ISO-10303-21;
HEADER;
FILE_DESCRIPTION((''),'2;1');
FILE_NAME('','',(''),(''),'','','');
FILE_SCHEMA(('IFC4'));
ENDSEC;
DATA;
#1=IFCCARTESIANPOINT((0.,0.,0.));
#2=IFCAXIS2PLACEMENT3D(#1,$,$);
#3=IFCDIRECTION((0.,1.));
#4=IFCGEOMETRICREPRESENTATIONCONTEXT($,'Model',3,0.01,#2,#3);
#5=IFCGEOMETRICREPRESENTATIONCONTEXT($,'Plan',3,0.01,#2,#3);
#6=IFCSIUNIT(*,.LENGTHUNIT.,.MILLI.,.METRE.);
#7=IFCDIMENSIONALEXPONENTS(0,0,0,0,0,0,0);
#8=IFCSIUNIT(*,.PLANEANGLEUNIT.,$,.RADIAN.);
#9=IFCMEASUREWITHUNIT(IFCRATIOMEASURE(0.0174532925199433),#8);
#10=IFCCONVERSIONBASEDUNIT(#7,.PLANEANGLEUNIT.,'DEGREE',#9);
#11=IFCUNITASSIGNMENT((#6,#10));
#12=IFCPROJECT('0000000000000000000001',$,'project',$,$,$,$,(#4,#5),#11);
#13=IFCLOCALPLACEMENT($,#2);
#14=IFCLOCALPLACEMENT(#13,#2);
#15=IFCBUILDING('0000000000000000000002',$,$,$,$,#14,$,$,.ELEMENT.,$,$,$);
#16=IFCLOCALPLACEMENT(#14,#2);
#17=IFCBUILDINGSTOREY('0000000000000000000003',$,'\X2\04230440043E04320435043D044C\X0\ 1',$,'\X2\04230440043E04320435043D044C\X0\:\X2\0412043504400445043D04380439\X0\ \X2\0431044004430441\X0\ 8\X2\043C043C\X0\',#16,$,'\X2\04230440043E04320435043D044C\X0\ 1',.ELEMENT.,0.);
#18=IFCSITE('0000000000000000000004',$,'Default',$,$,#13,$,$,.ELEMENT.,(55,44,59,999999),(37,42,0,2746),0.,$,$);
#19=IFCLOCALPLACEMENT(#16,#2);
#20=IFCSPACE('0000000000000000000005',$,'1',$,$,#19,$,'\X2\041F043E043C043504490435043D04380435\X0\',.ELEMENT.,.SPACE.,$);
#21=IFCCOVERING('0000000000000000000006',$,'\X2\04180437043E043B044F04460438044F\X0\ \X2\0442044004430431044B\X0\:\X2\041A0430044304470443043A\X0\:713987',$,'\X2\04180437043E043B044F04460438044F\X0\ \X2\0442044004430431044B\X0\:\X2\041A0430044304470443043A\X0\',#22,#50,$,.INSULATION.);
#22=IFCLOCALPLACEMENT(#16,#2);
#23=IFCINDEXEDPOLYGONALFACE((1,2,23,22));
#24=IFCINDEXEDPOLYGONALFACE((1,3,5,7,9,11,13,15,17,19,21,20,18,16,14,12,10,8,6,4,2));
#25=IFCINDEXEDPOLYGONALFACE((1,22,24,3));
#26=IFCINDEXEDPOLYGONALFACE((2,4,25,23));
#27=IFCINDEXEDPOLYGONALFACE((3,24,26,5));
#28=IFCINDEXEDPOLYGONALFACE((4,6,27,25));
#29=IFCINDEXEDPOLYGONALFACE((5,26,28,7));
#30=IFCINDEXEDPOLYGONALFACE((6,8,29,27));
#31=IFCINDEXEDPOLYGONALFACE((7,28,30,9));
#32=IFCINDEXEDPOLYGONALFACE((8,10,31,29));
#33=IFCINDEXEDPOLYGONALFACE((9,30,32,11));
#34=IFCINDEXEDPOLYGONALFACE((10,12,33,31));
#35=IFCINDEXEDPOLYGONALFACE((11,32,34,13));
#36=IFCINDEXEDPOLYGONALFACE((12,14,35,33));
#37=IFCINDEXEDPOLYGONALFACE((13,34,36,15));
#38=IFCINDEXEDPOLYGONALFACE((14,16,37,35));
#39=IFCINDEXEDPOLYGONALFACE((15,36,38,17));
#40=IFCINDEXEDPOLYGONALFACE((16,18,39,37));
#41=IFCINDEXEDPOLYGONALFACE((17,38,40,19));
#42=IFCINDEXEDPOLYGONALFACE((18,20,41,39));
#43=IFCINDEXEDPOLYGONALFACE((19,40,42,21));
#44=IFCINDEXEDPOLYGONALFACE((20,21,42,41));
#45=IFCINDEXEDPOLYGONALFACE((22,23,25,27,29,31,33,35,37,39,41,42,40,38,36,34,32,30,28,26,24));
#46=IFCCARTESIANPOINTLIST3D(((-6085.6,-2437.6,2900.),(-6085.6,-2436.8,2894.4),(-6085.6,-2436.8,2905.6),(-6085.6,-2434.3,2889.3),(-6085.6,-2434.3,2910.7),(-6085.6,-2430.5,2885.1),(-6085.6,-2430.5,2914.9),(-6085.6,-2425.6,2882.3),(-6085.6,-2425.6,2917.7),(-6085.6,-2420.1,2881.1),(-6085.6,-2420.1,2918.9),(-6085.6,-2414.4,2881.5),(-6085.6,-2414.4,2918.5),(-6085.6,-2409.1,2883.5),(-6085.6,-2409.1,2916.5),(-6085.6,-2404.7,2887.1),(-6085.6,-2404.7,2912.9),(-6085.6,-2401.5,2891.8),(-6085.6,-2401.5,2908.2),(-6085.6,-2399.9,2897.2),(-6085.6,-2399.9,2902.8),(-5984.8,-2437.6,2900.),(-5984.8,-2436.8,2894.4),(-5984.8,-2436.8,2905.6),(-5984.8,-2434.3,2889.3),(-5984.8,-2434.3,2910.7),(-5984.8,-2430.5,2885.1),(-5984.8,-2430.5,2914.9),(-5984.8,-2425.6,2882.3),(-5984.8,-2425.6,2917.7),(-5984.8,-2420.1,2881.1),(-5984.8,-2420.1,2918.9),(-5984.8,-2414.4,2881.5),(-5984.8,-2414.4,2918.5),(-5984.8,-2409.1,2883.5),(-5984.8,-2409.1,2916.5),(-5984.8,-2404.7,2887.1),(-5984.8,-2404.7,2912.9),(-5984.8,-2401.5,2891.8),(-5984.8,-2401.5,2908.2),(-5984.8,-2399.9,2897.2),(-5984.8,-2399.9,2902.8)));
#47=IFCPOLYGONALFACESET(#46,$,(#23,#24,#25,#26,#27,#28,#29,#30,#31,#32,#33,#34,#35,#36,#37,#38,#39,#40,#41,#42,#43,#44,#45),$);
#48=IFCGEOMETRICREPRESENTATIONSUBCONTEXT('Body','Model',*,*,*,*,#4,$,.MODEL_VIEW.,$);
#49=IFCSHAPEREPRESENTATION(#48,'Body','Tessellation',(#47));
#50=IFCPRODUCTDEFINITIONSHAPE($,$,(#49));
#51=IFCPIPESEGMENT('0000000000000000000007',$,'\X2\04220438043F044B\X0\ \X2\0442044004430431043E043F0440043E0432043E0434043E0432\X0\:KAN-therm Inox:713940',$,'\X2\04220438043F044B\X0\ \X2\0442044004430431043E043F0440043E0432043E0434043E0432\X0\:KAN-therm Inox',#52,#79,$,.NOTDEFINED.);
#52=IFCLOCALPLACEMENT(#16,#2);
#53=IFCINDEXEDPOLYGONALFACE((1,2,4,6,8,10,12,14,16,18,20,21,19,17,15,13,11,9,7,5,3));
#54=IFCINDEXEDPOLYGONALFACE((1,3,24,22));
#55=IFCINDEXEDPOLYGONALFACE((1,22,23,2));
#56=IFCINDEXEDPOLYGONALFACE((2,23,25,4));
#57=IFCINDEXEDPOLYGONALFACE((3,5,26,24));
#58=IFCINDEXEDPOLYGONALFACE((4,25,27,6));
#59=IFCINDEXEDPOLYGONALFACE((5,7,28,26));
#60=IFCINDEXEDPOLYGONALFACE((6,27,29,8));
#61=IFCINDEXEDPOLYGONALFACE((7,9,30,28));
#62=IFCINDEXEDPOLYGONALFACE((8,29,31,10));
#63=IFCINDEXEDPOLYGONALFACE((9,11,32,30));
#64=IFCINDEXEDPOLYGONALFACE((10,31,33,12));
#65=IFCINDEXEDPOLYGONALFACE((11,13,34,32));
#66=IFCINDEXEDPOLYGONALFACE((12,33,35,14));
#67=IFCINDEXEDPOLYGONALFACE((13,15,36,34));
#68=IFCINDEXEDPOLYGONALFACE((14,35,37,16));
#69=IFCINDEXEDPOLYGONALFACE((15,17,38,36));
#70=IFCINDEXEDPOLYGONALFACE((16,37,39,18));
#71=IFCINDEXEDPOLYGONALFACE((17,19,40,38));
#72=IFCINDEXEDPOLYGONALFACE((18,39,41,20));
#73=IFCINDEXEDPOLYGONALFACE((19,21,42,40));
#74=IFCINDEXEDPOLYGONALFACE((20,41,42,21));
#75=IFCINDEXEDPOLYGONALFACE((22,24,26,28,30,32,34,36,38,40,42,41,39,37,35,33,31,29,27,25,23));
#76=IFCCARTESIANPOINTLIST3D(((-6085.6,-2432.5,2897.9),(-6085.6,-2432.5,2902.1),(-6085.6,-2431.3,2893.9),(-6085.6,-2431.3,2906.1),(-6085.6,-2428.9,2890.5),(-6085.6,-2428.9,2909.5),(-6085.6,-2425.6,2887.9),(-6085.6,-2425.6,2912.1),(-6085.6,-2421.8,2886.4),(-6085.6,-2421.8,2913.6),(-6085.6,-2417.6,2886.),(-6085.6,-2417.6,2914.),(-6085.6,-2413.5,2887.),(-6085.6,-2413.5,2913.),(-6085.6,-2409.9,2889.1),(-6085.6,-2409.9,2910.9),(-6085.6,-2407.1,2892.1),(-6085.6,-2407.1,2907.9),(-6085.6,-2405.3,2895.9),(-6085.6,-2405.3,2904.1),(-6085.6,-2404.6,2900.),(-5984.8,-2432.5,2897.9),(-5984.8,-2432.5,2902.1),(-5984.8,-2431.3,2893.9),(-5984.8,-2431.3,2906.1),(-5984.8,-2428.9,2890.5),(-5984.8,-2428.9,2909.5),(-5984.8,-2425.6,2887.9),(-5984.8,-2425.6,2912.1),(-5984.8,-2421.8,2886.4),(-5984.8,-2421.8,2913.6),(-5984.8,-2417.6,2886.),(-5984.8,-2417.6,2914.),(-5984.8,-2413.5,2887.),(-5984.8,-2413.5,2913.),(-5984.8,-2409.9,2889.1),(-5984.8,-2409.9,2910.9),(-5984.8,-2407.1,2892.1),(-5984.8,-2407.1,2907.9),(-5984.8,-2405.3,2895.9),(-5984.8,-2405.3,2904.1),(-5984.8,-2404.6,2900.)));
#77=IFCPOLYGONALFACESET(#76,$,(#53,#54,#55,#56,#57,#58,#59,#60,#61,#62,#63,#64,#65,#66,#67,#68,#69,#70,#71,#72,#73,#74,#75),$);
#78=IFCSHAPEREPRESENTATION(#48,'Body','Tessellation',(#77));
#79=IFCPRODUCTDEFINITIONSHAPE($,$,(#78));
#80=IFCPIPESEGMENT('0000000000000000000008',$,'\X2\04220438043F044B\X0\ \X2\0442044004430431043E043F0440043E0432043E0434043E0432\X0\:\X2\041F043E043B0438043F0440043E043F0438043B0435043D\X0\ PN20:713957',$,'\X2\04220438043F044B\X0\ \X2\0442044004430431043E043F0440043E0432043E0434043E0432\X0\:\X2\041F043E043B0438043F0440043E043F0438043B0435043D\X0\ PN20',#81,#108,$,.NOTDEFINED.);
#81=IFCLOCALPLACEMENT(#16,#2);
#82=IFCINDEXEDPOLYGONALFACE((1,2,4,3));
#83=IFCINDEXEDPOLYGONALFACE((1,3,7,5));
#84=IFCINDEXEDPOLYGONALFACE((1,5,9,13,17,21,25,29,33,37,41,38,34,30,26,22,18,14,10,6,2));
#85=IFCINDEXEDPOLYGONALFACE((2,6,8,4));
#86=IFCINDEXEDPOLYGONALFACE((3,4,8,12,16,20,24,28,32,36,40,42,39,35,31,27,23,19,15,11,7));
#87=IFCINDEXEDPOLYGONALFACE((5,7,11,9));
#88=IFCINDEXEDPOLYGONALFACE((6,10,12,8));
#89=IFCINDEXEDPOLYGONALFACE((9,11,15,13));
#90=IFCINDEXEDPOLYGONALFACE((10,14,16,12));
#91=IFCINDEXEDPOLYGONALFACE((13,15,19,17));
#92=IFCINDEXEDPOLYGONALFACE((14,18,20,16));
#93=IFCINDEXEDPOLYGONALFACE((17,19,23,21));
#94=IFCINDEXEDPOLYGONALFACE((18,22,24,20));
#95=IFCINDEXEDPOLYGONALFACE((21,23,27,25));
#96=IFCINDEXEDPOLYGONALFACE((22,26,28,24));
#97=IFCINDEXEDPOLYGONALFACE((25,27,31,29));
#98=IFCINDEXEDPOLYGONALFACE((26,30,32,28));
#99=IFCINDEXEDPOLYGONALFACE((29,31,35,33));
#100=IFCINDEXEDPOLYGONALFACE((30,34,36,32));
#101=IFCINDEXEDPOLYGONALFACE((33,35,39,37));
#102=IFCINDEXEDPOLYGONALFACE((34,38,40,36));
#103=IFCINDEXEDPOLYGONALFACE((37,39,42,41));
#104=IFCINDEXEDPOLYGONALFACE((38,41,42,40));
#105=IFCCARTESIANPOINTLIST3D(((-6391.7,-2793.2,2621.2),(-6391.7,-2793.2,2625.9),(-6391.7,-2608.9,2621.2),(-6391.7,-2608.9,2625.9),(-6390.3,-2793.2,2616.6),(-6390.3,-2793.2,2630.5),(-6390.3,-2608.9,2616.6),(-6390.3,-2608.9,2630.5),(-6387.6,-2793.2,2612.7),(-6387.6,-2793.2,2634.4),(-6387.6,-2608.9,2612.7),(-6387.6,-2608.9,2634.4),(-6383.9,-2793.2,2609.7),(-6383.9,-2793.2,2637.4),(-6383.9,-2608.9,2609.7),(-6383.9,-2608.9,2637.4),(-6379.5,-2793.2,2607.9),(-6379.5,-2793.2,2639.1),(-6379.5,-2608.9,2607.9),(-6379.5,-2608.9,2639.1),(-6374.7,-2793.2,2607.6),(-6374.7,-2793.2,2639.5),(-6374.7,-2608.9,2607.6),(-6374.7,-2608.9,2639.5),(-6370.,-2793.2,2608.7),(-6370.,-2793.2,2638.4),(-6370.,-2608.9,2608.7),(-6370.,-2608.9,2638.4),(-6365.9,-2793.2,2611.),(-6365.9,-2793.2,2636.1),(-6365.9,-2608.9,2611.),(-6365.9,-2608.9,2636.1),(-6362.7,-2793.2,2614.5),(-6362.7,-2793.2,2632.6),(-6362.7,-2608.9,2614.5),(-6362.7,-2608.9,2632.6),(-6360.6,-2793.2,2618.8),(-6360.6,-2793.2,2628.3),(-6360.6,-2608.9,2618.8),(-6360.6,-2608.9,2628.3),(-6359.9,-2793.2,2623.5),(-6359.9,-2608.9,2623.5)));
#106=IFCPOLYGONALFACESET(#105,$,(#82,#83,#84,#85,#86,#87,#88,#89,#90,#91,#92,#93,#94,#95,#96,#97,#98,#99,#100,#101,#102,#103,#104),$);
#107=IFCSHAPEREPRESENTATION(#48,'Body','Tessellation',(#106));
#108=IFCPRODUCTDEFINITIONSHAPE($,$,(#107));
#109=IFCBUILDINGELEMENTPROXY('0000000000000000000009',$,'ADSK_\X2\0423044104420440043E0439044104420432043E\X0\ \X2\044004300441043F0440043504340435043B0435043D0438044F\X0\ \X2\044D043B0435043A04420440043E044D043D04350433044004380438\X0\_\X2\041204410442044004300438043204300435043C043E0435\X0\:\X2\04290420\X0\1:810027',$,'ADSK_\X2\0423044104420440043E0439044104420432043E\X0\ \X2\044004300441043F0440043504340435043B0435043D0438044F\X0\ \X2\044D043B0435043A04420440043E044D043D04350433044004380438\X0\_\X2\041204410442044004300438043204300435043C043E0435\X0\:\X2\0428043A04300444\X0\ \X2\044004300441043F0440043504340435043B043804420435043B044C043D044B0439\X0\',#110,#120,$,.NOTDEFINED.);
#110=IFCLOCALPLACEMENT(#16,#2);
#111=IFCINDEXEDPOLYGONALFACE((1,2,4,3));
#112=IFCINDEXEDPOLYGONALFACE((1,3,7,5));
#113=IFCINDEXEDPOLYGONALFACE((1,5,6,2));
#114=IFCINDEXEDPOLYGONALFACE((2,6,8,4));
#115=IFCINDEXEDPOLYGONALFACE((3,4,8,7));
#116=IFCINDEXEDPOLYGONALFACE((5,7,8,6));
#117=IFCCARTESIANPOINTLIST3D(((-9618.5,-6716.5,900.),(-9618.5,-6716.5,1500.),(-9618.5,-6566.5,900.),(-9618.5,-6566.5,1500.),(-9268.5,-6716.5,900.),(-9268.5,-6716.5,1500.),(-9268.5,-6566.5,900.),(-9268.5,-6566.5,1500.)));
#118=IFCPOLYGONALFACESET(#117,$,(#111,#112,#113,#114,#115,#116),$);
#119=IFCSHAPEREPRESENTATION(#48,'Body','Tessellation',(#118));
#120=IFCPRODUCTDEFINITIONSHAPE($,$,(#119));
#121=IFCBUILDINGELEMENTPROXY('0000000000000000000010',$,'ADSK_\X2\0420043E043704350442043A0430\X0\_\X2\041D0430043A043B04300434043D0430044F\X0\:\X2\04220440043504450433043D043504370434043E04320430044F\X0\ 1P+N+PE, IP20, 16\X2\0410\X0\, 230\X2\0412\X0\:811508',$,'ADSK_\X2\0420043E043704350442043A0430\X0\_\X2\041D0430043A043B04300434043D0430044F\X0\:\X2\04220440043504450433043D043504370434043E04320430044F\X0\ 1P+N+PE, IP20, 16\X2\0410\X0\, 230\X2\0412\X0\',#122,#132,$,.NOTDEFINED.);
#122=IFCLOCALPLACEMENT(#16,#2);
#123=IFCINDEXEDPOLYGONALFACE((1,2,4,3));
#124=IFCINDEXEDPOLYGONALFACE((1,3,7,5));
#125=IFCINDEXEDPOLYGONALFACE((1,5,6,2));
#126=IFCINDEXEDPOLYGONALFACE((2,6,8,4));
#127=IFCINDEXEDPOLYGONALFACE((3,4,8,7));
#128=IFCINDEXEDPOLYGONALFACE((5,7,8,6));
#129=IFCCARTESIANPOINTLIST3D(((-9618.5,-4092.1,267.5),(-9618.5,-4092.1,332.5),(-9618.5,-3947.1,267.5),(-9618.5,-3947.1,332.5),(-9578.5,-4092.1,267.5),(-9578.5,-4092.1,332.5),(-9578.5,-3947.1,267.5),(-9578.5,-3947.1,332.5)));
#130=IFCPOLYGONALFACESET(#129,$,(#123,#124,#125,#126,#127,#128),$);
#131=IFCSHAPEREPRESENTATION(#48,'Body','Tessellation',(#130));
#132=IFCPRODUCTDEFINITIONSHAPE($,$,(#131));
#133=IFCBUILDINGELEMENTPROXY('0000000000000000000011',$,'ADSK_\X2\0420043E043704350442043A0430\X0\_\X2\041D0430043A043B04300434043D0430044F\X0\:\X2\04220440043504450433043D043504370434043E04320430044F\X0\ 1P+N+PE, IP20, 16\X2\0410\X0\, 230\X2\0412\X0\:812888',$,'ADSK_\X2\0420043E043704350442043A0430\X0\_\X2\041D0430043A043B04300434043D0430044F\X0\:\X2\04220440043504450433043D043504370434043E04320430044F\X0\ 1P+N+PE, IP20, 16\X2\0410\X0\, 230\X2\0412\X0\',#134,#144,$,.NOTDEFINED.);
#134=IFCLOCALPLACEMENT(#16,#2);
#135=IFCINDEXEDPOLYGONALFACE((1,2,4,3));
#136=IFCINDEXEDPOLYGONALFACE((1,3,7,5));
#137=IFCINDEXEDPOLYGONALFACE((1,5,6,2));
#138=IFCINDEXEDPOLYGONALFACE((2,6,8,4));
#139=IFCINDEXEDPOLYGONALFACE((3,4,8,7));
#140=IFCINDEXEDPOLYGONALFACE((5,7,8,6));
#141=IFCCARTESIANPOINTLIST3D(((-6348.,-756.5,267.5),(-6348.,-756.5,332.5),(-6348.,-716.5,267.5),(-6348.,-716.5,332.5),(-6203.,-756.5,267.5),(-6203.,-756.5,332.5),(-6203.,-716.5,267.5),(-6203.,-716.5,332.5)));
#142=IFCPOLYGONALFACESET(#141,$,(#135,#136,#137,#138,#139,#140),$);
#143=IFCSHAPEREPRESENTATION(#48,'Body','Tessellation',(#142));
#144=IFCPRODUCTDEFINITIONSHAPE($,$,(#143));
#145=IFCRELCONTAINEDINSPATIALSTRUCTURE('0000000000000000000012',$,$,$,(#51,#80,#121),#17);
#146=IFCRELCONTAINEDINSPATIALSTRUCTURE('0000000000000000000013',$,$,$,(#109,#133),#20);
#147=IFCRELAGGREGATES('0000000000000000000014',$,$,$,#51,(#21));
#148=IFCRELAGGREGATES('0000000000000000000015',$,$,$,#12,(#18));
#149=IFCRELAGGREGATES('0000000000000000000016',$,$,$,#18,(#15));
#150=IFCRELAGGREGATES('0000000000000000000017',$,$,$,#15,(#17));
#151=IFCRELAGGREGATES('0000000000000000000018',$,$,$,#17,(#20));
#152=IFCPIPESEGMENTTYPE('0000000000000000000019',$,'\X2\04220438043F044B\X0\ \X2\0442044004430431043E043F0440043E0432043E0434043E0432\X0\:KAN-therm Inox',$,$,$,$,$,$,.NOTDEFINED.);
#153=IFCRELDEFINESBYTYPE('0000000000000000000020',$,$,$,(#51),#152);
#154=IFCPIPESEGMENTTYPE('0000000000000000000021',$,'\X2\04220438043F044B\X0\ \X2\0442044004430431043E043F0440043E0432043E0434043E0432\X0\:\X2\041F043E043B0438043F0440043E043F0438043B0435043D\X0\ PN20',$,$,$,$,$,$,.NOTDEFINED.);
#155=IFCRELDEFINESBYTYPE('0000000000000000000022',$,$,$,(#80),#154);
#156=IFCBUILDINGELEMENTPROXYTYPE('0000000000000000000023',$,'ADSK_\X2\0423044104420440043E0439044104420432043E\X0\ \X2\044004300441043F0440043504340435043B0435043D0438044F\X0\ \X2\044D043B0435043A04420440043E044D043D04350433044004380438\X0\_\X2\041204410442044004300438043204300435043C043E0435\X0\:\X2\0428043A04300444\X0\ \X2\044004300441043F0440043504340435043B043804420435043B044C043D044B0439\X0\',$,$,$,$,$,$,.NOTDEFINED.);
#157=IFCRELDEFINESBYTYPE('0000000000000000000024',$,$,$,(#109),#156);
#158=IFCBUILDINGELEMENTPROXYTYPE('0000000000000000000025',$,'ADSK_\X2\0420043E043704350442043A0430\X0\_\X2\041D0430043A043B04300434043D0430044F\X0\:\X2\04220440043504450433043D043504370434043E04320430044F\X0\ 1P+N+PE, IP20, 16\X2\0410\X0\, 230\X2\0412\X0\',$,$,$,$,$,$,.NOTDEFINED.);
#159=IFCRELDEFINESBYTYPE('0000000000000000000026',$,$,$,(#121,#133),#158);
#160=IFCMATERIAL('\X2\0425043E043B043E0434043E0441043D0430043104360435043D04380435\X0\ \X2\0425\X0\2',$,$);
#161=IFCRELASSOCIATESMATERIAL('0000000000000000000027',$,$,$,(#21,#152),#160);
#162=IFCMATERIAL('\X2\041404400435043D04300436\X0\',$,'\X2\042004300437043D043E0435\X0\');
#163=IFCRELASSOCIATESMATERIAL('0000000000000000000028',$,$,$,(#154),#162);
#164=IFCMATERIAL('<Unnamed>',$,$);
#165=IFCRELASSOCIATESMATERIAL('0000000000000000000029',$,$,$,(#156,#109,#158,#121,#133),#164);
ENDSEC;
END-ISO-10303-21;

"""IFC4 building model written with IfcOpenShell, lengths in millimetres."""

from ifc_helpers import new_model, entity, si_unit, converted_unit, direction, frame, frame_2d, origin, origin_2d_with_axis, place, context, subcontext, project, spatial, rectangle, circle, extrude, source, transform, mapped, material, type_object, type_shapes, element, aggregate, save


model = new_model("IFC4")

# Units and contexts
model_context = context("Model", 3, precision=0.01, world=origin(), true_north=direction((0.0, 1.0)))
plan_context = context("Plan", 3, precision=0.01, world=origin(), true_north=direction((0.0, 1.0)))
body_context = subcontext(model_context, "Body", "Model", "MODEL_VIEW")
ifc_project = project(units=[si_unit("LENGTHUNIT", "METRE", prefix="MILLI"), converted_unit("PLANEANGLEUNIT", "DEGREE", entity("IfcRatioMeasure", 0.0174532925199433), si_unit("PLANEANGLEUNIT", "RADIAN"), dimensions=[0, 0, 0, 0, 0, 0, 0])], contexts=[model_context, plan_context])

# Site, building, storey
site_placement = place(None, origin())
site = spatial("IfcSite", under=ifc_project, at=site_placement, Name="Default", CompositionType="ELEMENT", RefLatitude=(55, 44, 59, 999999), RefLongitude=(37, 42, 0, 2746), RefElevation=0.0)
building_placement = place(site_placement, origin())
building = spatial("IfcBuilding", under=site, at=building_placement, CompositionType="ELEMENT")
storey_placement = place(building_placement, origin())
storey = spatial("IfcBuildingStorey", under=building, at=storey_placement, Name="Уровень 1", ObjectType="Уровень:Верхний брус 8мм", LongName="Уровень 1", CompositionType="ELEMENT", Elevation=0.0)

# Covering
ifc_material_1 = material(Name="Холодоснабжение Х2")
covering_1_placement = place(storey_placement, frame((-6085.6, -2439.2, 2879.4)))
covering_1 = element("IfcCovering", 1, at=covering_1_placement, material=ifc_material_1, Name="Изоляция трубы:Каучук:713987", ObjectType="Изоляция трубы:Каучук", PredefinedType="INSULATION", context=body_context, shape_type="SweptSolid", body=[
    extrude(circle(Radius=19.0, at=frame_2d((0.0, 0.0), x_axis=(1.0, 0.0))), frame((0.0, 20.6, 20.6), z_axis=(1.0, 0.0, 0.0), x_axis=(0.0, -1.0, 0.0)), (0.0, 0.0, 1.0), 100.8),
])

# Pipe segment
pipe_segment_type_1 = type_object("IfcPipeSegmentType", Name="Типы трубопроводов:KAN-therm Inox", PredefinedType="NOTDEFINED", material=ifc_material_1)
pipe_segment_1_placement = place(storey_placement, frame((-6085.6, -2434.2, 2884.4)))
pipe_segment_1 = element("IfcPipeSegment", 2, at=pipe_segment_1_placement, inside=storey, type_object=pipe_segment_type_1, Name="Типы трубопроводов:KAN-therm Inox:713940", ObjectType="Типы трубопроводов:KAN-therm Inox", PredefinedType="NOTDEFINED", context=body_context, shape_type="SweptSolid", body=[
    extrude(circle(Radius=14.0, at=origin_2d_with_axis()), frame((0.0, 15.6, 15.6), z_axis=(1.0, 0.0, 0.0), x_axis=(0.0, 1.0, 0.0)), (0.0, 0.0, 1.0), 100.8),
])
aggregate(pipe_segment_1, [covering_1])

# Pipe segment
ifc_material_2 = material(Name="Дренаж", Category="Разное")
pipe_segment_type_2 = type_object("IfcPipeSegmentType", Name="Типы трубопроводов:Полипропилен PN20", PredefinedType="NOTDEFINED", material=ifc_material_2)
pipe_segment_2_placement = place(storey_placement, frame((-6393.5, -2793.2, 2606.0)))
element("IfcPipeSegment", 3, at=pipe_segment_2_placement, inside=storey, type_object=pipe_segment_type_2, Name="Типы трубопроводов:Полипропилен PN20:713957", ObjectType="Типы трубопроводов:Полипропилен PN20", PredefinedType="NOTDEFINED", context=body_context, shape_type="SweptSolid", body=[
    extrude(circle(Radius=16.0, at=frame_2d((0.0, 0.0), x_axis=(1.0, 0.0))), frame((17.6, 0.0, 17.6), z_axis=(-0.000002, 1.0, 0.0), x_axis=(1.0, 0.000002, 0.0)), (0.0, 0.0, 1.0), 184.3),
])

# Shared definitions
space_placement = place(storey_placement, origin())
space = spatial("IfcSpace", under=storey, at=space_placement, Name="1", LongName="Помещение", CompositionType="ELEMENT", PredefinedType="SPACE")

# Building element proxies
ifc_material_3 = material(Name="<Unnamed>")
building_element_proxy_type_1 = type_object("IfcBuildingElementProxyType", Name="ADSK_Устройство распределения электроэнегрии_Встраиваемое:Шкаф распределительный", PredefinedType="NOTDEFINED", material=ifc_material_3)
shared_shape_1 = source(origin(), body_context, "Body", "SweptSolid", [
    extrude(rectangle(XDim=150.0, YDim=350.0, at=origin_2d_with_axis()), frame((0.0, -75.0, -600.0), z_axis=(0.0, 0.0, 1.0), x_axis=(0.0, 1.0, 0.0)), (0.0, 0.0, 1.0), 600.0),
])
type_shapes(building_element_proxy_type_1, [shared_shape_1])
proxy_1_placement = place(space_placement, frame((-9443.5, -6566.5, 1500.0)))
element("IfcBuildingElementProxy", 4, at=proxy_1_placement, inside=space, type_object=building_element_proxy_type_1, material=ifc_material_3, Name="ADSK_Устройство распределения электроэнегрии_Встраиваемое:ЩР1:810027", ObjectType="ADSK_Устройство распределения электроэнегрии_Встраиваемое:Шкаф распределительный", PredefinedType="NOTDEFINED", context=body_context, shape_type="MappedRepresentation", body=[
    mapped(shared_shape_1, transform((0.0, 0.0, 0.0), scale=1.0)),
])
building_element_proxy_type_2 = type_object("IfcBuildingElementProxyType", Name="ADSK_Розетка_Накладная:Трехгнездовая 1P+N+PE, IP20, 16А, 230В", PredefinedType="NOTDEFINED", material=ifc_material_3)
shared_shape_2 = source(origin(), body_context, "Body", "SweptSolid", [
    extrude(rectangle(XDim=145.0, YDim=40.0, at=origin_2d_with_axis()), frame((0.0, 20.0, -32.5), z_axis=(0.0, 0.0, 1.0), x_axis=(-1.0, 0.0, 0.0)), (0.0, 0.0, 1.0), 65.0),
])
type_shapes(building_element_proxy_type_2, [shared_shape_2])
proxy_2_placement = place(storey_placement, frame((-9578.5, -4019.6, 300.0), z_axis=(0.0, 0.0, 1.0), x_axis=(0.0, 1.0, 0.0)))
element("IfcBuildingElementProxy", 5, at=proxy_2_placement, inside=storey, type_object=building_element_proxy_type_2, material=ifc_material_3, Name="ADSK_Розетка_Накладная:Трехгнездовая 1P+N+PE, IP20, 16А, 230В:811508", ObjectType="ADSK_Розетка_Накладная:Трехгнездовая 1P+N+PE, IP20, 16А, 230В", PredefinedType="NOTDEFINED", context=body_context, shape_type="MappedRepresentation", body=[
    mapped(shared_shape_2, transform((0.0, 0.0, 0.0), scale=1.0)),
])
proxy_3_placement = place(space_placement, frame((-6275.5, -716.5, 300.0), z_axis=(0.0, 0.0, 1.0), x_axis=(-1.0, 0.0, 0.0)))
element("IfcBuildingElementProxy", 6, at=proxy_3_placement, inside=space, type_object=building_element_proxy_type_2, material=ifc_material_3, Name="ADSK_Розетка_Накладная:Трехгнездовая 1P+N+PE, IP20, 16А, 230В:812888", ObjectType="ADSK_Розетка_Накладная:Трехгнездовая 1P+N+PE, IP20, 16А, 230В", PredefinedType="NOTDEFINED", context=body_context, shape_type="MappedRepresentation", body=[
    mapped(shared_shape_2, transform((0.0, 0.0, 0.0), scale=1.0)),
])

save(model, "model.ifc")
